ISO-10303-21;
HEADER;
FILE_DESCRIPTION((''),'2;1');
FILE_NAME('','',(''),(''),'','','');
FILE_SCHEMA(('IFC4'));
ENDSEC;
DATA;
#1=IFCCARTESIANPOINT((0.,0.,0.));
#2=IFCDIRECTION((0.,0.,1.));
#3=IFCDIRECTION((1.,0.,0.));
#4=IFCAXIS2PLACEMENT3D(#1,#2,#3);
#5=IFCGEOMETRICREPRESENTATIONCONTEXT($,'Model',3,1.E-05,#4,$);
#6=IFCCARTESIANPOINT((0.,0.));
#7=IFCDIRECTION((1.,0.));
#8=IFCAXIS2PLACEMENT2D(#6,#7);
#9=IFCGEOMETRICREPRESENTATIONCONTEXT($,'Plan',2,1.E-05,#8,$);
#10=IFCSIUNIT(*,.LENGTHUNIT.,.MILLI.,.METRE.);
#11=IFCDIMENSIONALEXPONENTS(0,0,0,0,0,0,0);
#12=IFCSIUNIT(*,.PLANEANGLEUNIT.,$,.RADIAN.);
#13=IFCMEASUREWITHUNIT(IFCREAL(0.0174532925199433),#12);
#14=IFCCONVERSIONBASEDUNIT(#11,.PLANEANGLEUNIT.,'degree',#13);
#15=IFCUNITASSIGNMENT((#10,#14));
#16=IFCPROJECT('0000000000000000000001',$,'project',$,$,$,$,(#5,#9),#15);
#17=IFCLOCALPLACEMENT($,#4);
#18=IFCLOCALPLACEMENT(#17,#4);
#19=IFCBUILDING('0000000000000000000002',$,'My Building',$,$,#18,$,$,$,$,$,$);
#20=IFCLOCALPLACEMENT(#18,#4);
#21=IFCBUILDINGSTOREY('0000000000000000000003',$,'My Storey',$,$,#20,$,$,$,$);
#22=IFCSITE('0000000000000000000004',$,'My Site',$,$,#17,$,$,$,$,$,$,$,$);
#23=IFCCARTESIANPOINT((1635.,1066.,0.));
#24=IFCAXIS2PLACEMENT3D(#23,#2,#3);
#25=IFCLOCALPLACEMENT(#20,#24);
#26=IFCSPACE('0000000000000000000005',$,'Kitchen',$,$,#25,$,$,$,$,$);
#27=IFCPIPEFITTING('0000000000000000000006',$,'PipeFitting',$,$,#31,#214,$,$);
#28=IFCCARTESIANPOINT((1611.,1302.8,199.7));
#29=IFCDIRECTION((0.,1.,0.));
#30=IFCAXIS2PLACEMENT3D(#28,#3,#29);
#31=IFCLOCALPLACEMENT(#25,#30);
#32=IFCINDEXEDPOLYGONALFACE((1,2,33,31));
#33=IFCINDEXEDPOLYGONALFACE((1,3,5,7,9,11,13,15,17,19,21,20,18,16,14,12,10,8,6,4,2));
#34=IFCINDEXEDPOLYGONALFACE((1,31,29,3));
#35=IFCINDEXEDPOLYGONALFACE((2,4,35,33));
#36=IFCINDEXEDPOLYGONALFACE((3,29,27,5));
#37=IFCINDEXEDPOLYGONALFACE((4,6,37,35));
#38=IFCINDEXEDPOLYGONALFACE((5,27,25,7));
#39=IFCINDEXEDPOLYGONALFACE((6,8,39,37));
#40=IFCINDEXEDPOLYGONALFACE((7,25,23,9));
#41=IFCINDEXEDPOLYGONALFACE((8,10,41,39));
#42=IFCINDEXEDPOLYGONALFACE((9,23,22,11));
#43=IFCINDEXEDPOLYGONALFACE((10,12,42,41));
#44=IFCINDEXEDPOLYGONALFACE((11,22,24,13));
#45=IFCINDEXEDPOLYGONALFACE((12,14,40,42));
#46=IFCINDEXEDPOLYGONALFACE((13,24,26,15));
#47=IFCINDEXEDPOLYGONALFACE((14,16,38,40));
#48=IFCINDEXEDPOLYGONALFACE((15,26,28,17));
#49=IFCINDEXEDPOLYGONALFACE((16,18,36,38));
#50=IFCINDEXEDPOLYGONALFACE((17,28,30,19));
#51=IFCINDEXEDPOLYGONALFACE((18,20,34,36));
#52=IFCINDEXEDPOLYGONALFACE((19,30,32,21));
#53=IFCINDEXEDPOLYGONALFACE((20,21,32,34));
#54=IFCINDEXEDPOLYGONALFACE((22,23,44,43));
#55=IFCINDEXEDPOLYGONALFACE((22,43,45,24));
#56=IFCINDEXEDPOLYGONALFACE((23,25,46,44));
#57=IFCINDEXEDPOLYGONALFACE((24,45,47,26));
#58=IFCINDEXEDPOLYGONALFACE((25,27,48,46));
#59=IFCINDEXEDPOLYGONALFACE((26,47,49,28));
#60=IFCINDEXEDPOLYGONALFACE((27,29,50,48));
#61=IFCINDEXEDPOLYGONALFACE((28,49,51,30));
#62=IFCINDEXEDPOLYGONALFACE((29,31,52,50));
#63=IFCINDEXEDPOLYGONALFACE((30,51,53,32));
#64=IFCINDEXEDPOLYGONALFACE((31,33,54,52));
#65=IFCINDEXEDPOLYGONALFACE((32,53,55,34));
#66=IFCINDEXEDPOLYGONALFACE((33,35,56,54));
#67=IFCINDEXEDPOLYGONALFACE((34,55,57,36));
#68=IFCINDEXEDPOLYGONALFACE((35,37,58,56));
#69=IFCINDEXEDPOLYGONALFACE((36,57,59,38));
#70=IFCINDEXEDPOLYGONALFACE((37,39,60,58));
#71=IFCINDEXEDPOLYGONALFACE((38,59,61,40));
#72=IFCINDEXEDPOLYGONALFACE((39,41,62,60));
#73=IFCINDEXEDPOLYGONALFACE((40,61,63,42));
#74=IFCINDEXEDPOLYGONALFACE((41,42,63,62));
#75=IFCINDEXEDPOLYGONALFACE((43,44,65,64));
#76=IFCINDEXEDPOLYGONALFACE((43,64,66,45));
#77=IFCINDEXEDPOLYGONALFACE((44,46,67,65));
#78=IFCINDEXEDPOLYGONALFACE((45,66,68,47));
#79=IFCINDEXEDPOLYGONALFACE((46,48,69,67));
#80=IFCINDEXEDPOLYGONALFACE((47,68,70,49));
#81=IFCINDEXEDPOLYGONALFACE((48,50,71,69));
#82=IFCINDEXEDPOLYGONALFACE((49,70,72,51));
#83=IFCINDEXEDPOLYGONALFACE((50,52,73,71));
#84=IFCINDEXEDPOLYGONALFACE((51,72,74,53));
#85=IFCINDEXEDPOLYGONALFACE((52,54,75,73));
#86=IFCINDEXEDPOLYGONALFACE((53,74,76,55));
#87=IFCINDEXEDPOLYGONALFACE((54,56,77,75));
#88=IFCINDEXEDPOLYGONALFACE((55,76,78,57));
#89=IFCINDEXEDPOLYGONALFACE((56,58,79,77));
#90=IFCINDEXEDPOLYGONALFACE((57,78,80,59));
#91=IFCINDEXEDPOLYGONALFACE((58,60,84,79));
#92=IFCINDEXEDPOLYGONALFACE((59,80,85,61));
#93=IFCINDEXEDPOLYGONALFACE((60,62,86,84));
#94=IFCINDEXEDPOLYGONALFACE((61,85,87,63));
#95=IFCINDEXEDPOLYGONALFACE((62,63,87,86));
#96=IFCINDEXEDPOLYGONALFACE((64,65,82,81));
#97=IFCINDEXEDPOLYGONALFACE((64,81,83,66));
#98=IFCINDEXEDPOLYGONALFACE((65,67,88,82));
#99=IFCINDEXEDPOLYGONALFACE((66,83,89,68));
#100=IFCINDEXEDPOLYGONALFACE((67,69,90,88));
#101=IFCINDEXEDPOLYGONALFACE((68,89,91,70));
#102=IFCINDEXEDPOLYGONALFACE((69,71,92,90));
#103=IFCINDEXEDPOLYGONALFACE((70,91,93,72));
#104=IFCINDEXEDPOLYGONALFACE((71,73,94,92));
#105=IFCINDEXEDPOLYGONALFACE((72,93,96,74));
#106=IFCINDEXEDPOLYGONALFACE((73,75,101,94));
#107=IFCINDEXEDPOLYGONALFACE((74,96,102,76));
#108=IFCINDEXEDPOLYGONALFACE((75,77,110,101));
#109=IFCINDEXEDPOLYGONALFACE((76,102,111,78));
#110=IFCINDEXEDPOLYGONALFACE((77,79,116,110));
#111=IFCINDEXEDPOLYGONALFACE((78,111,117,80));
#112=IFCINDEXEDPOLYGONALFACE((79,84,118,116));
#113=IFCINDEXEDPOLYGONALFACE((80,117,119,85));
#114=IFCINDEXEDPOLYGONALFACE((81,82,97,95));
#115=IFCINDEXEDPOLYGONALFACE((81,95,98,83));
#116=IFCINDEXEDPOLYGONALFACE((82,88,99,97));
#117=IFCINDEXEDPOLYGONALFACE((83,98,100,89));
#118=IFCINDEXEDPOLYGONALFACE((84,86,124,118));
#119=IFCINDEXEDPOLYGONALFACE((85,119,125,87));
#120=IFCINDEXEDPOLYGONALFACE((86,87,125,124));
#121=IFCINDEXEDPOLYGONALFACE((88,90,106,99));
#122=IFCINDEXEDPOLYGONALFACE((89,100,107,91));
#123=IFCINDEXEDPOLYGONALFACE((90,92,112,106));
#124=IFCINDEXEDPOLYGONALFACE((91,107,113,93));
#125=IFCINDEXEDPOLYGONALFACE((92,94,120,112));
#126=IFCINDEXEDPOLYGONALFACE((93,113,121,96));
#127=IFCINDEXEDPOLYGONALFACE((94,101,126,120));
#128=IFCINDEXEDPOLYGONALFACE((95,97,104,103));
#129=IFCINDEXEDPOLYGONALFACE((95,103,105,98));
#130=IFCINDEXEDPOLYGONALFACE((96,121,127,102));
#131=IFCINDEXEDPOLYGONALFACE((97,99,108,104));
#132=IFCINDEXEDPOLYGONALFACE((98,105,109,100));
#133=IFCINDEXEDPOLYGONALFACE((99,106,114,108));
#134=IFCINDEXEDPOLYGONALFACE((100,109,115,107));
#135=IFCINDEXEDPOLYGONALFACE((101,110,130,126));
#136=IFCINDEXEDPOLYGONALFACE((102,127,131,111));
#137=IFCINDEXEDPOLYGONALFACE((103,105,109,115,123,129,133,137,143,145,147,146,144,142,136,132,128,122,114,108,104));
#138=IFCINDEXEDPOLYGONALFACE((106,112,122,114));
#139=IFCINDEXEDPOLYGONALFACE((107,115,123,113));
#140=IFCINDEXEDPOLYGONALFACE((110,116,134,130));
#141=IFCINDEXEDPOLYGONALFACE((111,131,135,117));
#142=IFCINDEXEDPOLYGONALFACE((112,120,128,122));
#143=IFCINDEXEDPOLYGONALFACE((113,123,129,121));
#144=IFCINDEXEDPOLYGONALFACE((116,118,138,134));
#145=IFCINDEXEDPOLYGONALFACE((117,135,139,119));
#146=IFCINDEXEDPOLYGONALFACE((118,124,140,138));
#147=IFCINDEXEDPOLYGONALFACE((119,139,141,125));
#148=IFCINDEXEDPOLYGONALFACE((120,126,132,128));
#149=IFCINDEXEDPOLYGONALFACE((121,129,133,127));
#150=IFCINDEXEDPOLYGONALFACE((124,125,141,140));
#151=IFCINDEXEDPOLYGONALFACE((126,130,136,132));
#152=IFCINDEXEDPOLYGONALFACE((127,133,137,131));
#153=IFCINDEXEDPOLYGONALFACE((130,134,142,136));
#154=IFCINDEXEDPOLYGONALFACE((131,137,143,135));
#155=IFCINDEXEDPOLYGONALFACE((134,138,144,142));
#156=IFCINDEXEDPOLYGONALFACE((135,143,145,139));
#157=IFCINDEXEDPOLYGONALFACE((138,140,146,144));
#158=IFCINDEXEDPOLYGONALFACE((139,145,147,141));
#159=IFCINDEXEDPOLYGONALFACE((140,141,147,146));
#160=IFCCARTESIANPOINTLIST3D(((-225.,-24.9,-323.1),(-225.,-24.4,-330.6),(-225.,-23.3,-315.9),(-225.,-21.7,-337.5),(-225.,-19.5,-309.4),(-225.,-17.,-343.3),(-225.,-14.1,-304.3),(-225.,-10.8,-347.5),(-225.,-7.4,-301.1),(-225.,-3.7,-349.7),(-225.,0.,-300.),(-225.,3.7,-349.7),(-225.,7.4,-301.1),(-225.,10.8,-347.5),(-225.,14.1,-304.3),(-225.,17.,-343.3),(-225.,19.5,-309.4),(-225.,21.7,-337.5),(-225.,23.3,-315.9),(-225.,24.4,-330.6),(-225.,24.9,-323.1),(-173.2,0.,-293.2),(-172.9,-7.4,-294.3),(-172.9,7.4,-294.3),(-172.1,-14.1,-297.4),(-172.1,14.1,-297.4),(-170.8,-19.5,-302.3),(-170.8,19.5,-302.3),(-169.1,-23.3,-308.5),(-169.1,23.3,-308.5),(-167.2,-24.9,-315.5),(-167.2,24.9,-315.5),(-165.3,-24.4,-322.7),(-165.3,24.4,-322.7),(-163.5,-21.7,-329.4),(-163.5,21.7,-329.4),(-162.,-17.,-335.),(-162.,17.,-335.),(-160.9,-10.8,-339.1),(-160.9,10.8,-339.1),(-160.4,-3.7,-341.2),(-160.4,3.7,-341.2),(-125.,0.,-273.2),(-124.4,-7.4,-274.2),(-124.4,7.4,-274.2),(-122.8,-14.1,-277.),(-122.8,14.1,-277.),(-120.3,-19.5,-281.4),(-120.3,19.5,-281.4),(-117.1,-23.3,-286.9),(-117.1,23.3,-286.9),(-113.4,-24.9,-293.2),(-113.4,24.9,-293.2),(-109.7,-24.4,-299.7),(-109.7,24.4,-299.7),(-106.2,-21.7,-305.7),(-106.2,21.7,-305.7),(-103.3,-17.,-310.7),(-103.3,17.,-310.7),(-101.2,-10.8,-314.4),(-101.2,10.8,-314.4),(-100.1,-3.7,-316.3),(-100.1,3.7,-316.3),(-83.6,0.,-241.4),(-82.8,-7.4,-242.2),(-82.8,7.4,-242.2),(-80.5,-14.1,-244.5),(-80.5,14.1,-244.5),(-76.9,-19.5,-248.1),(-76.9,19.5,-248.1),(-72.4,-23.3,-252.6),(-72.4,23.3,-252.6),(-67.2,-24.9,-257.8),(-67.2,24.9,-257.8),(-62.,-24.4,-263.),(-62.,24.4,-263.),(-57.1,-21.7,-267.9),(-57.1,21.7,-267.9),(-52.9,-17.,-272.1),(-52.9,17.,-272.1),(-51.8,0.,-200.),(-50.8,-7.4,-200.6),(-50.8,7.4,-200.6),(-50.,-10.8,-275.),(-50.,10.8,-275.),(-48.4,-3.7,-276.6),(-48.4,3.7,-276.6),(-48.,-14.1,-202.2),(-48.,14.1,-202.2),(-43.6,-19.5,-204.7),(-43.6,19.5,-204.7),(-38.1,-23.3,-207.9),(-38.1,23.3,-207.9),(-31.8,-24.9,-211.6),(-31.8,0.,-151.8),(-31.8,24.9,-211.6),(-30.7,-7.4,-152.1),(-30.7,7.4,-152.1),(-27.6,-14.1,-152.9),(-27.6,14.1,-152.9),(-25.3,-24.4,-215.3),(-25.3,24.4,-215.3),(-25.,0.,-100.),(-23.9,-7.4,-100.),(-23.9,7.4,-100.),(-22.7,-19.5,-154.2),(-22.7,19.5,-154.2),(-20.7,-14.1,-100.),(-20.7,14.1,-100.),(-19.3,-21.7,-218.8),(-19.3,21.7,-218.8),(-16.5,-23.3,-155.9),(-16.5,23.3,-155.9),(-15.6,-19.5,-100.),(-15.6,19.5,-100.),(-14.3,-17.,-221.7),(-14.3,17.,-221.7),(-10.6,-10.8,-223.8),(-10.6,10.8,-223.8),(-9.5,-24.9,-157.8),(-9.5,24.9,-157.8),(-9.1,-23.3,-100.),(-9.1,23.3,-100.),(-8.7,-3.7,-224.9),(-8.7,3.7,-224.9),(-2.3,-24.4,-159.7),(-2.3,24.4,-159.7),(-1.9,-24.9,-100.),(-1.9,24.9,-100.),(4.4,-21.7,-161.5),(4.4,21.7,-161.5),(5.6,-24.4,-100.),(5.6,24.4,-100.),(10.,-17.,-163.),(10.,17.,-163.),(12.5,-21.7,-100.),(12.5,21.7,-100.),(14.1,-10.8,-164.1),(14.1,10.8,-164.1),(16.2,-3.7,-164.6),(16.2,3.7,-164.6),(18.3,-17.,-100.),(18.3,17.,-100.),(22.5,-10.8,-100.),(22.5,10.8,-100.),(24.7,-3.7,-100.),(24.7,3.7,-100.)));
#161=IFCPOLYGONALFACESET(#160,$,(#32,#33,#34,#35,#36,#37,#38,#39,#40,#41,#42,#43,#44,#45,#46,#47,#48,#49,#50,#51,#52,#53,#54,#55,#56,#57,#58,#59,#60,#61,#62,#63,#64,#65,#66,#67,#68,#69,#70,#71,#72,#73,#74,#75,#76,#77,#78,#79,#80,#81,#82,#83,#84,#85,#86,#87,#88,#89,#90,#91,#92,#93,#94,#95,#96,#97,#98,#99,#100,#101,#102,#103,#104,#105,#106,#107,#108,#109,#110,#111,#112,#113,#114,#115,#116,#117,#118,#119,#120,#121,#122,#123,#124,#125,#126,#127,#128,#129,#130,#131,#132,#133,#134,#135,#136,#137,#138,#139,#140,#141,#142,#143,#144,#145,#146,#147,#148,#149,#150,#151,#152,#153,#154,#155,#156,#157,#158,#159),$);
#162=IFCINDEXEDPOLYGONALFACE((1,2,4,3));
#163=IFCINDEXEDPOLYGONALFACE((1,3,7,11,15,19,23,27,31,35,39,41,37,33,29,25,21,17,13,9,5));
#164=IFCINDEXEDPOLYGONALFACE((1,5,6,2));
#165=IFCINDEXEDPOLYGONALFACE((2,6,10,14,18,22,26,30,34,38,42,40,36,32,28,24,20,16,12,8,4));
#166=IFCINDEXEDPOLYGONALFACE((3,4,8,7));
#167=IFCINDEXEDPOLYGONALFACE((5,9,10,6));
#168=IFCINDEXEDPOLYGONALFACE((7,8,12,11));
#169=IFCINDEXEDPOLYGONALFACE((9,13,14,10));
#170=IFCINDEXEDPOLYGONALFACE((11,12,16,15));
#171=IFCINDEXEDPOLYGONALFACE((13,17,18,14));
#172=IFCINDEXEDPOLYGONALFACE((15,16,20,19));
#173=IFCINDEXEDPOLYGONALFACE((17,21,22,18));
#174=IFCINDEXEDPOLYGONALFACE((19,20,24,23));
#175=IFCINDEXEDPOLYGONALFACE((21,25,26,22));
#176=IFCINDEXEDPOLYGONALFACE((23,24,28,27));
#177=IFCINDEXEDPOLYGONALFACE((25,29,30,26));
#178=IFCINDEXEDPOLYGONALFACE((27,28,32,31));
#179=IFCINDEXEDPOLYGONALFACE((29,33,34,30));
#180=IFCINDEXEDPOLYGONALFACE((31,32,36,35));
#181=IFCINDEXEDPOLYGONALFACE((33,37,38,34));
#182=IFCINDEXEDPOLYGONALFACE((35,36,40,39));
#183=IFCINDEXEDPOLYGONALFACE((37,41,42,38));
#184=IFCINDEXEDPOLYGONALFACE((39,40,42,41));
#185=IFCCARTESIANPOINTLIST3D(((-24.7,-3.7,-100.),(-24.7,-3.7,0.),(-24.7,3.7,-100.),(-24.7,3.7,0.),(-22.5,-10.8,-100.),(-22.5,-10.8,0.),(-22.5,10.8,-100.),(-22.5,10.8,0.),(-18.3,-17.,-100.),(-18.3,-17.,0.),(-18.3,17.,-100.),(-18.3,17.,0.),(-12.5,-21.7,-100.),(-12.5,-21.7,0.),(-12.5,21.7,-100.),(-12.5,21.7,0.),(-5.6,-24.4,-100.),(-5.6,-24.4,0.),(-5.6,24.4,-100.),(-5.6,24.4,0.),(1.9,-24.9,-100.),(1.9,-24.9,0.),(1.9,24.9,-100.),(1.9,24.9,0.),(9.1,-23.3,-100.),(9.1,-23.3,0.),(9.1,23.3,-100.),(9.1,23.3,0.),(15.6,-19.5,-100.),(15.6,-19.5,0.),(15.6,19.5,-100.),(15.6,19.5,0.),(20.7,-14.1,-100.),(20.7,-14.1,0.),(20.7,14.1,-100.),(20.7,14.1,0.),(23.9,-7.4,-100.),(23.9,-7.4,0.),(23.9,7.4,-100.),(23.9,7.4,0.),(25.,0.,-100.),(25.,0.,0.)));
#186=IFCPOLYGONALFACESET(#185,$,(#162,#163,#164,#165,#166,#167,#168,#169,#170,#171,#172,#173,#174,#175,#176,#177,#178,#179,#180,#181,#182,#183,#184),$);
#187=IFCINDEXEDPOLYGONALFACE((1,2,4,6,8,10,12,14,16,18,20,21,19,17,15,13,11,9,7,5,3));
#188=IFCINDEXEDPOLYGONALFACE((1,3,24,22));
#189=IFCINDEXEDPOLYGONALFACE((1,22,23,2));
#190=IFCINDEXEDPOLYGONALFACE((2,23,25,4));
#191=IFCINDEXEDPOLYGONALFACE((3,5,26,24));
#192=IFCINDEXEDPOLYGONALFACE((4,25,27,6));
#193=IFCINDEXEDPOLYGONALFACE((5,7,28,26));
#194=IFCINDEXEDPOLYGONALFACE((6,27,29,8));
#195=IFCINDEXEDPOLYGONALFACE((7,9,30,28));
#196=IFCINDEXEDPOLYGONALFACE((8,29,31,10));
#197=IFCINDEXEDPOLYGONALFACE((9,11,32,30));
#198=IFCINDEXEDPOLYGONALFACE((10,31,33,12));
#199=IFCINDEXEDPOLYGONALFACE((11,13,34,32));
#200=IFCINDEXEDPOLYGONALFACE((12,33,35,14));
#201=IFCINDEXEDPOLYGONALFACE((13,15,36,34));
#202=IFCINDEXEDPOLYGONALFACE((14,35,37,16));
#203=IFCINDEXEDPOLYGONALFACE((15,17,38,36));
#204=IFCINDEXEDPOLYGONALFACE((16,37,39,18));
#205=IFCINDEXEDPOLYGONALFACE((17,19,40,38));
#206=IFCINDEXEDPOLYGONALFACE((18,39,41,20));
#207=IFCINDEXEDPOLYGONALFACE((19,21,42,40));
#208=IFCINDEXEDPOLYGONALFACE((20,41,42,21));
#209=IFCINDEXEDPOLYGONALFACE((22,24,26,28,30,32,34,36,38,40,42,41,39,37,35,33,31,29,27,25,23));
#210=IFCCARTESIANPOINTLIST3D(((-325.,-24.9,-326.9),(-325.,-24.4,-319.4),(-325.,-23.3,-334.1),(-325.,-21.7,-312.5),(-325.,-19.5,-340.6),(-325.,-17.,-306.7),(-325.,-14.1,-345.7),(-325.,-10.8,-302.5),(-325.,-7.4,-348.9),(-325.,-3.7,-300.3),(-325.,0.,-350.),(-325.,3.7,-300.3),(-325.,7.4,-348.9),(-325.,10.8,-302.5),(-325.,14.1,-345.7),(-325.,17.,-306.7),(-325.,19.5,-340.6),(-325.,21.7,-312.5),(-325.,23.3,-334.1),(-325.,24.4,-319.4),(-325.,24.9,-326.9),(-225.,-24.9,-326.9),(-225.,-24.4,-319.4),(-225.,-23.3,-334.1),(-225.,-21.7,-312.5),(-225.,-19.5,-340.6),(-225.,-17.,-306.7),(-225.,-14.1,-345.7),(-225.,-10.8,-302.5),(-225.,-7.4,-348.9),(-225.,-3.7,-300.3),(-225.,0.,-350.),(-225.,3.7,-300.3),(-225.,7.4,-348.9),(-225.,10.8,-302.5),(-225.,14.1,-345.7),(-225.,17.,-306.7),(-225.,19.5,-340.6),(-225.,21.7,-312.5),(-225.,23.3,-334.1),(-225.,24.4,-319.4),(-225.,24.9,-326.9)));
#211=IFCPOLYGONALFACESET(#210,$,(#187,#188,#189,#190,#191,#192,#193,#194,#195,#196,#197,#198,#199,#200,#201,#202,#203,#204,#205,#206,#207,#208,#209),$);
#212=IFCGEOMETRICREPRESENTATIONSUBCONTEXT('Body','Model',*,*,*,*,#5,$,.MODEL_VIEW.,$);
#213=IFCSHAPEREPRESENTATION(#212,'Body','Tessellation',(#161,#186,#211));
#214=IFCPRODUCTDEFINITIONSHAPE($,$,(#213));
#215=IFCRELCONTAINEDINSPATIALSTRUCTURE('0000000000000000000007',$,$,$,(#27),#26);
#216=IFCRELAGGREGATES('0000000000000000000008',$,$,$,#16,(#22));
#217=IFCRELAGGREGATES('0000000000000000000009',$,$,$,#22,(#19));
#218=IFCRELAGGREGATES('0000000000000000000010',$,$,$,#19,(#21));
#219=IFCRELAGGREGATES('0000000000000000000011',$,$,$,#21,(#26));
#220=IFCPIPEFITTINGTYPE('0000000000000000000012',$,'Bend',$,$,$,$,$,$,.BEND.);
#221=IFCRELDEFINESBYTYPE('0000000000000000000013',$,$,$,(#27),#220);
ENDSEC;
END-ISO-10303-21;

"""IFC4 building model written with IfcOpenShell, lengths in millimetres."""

from ifc_helpers import new_model, entity, si_unit, converted_unit, frame, origin_with_axes, origin_2d_with_axis, place, context, subcontext, project, spatial, circle, extrude, source, transform, mapped, type_object, type_shapes, element, save


model = new_model("IFC4")

# Units and contexts
model_context = context("Model", 3, precision=1e-05, world=origin_with_axes())
plan_context = context("Plan", 2, precision=1e-05, world=origin_2d_with_axis())
body_context = subcontext(model_context, "Body", "Model", "MODEL_VIEW")
ifc_project = project(units=[si_unit("LENGTHUNIT", "METRE", prefix="MILLI"), converted_unit("PLANEANGLEUNIT", "degree", entity("IfcReal", 0.0174532925199433), si_unit("PLANEANGLEUNIT", "RADIAN"), dimensions=[0, 0, 0, 0, 0, 0, 0])], contexts=[model_context, plan_context])

# Site, building, storey
site_placement = place(None, origin_with_axes())
site = spatial("IfcSite", under=ifc_project, at=site_placement, Name="My Site")
building_placement = place(site_placement, origin_with_axes())
building = spatial("IfcBuilding", under=site, at=building_placement, Name="My Building")
storey_placement = place(building_placement, origin_with_axes())
storey = spatial("IfcBuildingStorey", under=building, at=storey_placement, Name="My Storey")

# Shared definitions
space_1_placement = place(storey_placement, frame((1635.0, 1066.0, 0.0), z_axis=(0.0, 0.0, 1.0), x_axis=(1.0, 0.0, 0.0)))
space_1 = spatial("IfcSpace", under=storey, at=space_1_placement, Name="Kitchen")

# Pipe fitting
pipe_fitting_type = type_object("IfcPipeFittingType", Name="Bend", PredefinedType="BEND")
shared_shape_1 = source(origin_with_axes(), body_context, "Body", "AdvancedSweptSolid", [
    entity("IfcSweptDiskSolid", entity("IfcIndexedPolyCurve", entity("IfcCartesianPointList3D", [[0.0, 0.0, -100.0], [-65.9, 0.0, -259.1], [-225.0, 0.0, -325.0]]), [entity("IfcArcIndex", [1, 2, 3])]), 25.0),
    extrude(circle(Radius=25.0), origin_with_axes(), (0.0, 0.0, -1.0), 100.0),
    extrude(circle(Radius=25.0), frame((-225.0, 0.0, -325.0), z_axis=(-1.0, 0.0, 0.0), x_axis=(0.0, 0.0, -1.0)), (0.0, 0.0, 1.0), 100.0),
])
type_shapes(pipe_fitting_type, [shared_shape_1])
pipe_fitting_placement = place(space_1_placement, frame((1611.0, 1302.8, 199.7), z_axis=(1.0, 0.0, 0.0), x_axis=(0.0, 1.0, 0.0)))
element("IfcPipeFitting", 1, at=pipe_fitting_placement, inside=space_1, type_object=pipe_fitting_type, Name="PipeFitting", context=body_context, shape_type="MappedRepresentation", body=[
    mapped(shared_shape_1, transform((0.0, 0.0, 0.0), x_axis=(1.0, 0.0, 0.0), y_axis=(0.0, 1.0, 0.0), z_axis=(0.0, 0.0, 1.0), scale=1.0)),
])

save(model, "model.ifc")
